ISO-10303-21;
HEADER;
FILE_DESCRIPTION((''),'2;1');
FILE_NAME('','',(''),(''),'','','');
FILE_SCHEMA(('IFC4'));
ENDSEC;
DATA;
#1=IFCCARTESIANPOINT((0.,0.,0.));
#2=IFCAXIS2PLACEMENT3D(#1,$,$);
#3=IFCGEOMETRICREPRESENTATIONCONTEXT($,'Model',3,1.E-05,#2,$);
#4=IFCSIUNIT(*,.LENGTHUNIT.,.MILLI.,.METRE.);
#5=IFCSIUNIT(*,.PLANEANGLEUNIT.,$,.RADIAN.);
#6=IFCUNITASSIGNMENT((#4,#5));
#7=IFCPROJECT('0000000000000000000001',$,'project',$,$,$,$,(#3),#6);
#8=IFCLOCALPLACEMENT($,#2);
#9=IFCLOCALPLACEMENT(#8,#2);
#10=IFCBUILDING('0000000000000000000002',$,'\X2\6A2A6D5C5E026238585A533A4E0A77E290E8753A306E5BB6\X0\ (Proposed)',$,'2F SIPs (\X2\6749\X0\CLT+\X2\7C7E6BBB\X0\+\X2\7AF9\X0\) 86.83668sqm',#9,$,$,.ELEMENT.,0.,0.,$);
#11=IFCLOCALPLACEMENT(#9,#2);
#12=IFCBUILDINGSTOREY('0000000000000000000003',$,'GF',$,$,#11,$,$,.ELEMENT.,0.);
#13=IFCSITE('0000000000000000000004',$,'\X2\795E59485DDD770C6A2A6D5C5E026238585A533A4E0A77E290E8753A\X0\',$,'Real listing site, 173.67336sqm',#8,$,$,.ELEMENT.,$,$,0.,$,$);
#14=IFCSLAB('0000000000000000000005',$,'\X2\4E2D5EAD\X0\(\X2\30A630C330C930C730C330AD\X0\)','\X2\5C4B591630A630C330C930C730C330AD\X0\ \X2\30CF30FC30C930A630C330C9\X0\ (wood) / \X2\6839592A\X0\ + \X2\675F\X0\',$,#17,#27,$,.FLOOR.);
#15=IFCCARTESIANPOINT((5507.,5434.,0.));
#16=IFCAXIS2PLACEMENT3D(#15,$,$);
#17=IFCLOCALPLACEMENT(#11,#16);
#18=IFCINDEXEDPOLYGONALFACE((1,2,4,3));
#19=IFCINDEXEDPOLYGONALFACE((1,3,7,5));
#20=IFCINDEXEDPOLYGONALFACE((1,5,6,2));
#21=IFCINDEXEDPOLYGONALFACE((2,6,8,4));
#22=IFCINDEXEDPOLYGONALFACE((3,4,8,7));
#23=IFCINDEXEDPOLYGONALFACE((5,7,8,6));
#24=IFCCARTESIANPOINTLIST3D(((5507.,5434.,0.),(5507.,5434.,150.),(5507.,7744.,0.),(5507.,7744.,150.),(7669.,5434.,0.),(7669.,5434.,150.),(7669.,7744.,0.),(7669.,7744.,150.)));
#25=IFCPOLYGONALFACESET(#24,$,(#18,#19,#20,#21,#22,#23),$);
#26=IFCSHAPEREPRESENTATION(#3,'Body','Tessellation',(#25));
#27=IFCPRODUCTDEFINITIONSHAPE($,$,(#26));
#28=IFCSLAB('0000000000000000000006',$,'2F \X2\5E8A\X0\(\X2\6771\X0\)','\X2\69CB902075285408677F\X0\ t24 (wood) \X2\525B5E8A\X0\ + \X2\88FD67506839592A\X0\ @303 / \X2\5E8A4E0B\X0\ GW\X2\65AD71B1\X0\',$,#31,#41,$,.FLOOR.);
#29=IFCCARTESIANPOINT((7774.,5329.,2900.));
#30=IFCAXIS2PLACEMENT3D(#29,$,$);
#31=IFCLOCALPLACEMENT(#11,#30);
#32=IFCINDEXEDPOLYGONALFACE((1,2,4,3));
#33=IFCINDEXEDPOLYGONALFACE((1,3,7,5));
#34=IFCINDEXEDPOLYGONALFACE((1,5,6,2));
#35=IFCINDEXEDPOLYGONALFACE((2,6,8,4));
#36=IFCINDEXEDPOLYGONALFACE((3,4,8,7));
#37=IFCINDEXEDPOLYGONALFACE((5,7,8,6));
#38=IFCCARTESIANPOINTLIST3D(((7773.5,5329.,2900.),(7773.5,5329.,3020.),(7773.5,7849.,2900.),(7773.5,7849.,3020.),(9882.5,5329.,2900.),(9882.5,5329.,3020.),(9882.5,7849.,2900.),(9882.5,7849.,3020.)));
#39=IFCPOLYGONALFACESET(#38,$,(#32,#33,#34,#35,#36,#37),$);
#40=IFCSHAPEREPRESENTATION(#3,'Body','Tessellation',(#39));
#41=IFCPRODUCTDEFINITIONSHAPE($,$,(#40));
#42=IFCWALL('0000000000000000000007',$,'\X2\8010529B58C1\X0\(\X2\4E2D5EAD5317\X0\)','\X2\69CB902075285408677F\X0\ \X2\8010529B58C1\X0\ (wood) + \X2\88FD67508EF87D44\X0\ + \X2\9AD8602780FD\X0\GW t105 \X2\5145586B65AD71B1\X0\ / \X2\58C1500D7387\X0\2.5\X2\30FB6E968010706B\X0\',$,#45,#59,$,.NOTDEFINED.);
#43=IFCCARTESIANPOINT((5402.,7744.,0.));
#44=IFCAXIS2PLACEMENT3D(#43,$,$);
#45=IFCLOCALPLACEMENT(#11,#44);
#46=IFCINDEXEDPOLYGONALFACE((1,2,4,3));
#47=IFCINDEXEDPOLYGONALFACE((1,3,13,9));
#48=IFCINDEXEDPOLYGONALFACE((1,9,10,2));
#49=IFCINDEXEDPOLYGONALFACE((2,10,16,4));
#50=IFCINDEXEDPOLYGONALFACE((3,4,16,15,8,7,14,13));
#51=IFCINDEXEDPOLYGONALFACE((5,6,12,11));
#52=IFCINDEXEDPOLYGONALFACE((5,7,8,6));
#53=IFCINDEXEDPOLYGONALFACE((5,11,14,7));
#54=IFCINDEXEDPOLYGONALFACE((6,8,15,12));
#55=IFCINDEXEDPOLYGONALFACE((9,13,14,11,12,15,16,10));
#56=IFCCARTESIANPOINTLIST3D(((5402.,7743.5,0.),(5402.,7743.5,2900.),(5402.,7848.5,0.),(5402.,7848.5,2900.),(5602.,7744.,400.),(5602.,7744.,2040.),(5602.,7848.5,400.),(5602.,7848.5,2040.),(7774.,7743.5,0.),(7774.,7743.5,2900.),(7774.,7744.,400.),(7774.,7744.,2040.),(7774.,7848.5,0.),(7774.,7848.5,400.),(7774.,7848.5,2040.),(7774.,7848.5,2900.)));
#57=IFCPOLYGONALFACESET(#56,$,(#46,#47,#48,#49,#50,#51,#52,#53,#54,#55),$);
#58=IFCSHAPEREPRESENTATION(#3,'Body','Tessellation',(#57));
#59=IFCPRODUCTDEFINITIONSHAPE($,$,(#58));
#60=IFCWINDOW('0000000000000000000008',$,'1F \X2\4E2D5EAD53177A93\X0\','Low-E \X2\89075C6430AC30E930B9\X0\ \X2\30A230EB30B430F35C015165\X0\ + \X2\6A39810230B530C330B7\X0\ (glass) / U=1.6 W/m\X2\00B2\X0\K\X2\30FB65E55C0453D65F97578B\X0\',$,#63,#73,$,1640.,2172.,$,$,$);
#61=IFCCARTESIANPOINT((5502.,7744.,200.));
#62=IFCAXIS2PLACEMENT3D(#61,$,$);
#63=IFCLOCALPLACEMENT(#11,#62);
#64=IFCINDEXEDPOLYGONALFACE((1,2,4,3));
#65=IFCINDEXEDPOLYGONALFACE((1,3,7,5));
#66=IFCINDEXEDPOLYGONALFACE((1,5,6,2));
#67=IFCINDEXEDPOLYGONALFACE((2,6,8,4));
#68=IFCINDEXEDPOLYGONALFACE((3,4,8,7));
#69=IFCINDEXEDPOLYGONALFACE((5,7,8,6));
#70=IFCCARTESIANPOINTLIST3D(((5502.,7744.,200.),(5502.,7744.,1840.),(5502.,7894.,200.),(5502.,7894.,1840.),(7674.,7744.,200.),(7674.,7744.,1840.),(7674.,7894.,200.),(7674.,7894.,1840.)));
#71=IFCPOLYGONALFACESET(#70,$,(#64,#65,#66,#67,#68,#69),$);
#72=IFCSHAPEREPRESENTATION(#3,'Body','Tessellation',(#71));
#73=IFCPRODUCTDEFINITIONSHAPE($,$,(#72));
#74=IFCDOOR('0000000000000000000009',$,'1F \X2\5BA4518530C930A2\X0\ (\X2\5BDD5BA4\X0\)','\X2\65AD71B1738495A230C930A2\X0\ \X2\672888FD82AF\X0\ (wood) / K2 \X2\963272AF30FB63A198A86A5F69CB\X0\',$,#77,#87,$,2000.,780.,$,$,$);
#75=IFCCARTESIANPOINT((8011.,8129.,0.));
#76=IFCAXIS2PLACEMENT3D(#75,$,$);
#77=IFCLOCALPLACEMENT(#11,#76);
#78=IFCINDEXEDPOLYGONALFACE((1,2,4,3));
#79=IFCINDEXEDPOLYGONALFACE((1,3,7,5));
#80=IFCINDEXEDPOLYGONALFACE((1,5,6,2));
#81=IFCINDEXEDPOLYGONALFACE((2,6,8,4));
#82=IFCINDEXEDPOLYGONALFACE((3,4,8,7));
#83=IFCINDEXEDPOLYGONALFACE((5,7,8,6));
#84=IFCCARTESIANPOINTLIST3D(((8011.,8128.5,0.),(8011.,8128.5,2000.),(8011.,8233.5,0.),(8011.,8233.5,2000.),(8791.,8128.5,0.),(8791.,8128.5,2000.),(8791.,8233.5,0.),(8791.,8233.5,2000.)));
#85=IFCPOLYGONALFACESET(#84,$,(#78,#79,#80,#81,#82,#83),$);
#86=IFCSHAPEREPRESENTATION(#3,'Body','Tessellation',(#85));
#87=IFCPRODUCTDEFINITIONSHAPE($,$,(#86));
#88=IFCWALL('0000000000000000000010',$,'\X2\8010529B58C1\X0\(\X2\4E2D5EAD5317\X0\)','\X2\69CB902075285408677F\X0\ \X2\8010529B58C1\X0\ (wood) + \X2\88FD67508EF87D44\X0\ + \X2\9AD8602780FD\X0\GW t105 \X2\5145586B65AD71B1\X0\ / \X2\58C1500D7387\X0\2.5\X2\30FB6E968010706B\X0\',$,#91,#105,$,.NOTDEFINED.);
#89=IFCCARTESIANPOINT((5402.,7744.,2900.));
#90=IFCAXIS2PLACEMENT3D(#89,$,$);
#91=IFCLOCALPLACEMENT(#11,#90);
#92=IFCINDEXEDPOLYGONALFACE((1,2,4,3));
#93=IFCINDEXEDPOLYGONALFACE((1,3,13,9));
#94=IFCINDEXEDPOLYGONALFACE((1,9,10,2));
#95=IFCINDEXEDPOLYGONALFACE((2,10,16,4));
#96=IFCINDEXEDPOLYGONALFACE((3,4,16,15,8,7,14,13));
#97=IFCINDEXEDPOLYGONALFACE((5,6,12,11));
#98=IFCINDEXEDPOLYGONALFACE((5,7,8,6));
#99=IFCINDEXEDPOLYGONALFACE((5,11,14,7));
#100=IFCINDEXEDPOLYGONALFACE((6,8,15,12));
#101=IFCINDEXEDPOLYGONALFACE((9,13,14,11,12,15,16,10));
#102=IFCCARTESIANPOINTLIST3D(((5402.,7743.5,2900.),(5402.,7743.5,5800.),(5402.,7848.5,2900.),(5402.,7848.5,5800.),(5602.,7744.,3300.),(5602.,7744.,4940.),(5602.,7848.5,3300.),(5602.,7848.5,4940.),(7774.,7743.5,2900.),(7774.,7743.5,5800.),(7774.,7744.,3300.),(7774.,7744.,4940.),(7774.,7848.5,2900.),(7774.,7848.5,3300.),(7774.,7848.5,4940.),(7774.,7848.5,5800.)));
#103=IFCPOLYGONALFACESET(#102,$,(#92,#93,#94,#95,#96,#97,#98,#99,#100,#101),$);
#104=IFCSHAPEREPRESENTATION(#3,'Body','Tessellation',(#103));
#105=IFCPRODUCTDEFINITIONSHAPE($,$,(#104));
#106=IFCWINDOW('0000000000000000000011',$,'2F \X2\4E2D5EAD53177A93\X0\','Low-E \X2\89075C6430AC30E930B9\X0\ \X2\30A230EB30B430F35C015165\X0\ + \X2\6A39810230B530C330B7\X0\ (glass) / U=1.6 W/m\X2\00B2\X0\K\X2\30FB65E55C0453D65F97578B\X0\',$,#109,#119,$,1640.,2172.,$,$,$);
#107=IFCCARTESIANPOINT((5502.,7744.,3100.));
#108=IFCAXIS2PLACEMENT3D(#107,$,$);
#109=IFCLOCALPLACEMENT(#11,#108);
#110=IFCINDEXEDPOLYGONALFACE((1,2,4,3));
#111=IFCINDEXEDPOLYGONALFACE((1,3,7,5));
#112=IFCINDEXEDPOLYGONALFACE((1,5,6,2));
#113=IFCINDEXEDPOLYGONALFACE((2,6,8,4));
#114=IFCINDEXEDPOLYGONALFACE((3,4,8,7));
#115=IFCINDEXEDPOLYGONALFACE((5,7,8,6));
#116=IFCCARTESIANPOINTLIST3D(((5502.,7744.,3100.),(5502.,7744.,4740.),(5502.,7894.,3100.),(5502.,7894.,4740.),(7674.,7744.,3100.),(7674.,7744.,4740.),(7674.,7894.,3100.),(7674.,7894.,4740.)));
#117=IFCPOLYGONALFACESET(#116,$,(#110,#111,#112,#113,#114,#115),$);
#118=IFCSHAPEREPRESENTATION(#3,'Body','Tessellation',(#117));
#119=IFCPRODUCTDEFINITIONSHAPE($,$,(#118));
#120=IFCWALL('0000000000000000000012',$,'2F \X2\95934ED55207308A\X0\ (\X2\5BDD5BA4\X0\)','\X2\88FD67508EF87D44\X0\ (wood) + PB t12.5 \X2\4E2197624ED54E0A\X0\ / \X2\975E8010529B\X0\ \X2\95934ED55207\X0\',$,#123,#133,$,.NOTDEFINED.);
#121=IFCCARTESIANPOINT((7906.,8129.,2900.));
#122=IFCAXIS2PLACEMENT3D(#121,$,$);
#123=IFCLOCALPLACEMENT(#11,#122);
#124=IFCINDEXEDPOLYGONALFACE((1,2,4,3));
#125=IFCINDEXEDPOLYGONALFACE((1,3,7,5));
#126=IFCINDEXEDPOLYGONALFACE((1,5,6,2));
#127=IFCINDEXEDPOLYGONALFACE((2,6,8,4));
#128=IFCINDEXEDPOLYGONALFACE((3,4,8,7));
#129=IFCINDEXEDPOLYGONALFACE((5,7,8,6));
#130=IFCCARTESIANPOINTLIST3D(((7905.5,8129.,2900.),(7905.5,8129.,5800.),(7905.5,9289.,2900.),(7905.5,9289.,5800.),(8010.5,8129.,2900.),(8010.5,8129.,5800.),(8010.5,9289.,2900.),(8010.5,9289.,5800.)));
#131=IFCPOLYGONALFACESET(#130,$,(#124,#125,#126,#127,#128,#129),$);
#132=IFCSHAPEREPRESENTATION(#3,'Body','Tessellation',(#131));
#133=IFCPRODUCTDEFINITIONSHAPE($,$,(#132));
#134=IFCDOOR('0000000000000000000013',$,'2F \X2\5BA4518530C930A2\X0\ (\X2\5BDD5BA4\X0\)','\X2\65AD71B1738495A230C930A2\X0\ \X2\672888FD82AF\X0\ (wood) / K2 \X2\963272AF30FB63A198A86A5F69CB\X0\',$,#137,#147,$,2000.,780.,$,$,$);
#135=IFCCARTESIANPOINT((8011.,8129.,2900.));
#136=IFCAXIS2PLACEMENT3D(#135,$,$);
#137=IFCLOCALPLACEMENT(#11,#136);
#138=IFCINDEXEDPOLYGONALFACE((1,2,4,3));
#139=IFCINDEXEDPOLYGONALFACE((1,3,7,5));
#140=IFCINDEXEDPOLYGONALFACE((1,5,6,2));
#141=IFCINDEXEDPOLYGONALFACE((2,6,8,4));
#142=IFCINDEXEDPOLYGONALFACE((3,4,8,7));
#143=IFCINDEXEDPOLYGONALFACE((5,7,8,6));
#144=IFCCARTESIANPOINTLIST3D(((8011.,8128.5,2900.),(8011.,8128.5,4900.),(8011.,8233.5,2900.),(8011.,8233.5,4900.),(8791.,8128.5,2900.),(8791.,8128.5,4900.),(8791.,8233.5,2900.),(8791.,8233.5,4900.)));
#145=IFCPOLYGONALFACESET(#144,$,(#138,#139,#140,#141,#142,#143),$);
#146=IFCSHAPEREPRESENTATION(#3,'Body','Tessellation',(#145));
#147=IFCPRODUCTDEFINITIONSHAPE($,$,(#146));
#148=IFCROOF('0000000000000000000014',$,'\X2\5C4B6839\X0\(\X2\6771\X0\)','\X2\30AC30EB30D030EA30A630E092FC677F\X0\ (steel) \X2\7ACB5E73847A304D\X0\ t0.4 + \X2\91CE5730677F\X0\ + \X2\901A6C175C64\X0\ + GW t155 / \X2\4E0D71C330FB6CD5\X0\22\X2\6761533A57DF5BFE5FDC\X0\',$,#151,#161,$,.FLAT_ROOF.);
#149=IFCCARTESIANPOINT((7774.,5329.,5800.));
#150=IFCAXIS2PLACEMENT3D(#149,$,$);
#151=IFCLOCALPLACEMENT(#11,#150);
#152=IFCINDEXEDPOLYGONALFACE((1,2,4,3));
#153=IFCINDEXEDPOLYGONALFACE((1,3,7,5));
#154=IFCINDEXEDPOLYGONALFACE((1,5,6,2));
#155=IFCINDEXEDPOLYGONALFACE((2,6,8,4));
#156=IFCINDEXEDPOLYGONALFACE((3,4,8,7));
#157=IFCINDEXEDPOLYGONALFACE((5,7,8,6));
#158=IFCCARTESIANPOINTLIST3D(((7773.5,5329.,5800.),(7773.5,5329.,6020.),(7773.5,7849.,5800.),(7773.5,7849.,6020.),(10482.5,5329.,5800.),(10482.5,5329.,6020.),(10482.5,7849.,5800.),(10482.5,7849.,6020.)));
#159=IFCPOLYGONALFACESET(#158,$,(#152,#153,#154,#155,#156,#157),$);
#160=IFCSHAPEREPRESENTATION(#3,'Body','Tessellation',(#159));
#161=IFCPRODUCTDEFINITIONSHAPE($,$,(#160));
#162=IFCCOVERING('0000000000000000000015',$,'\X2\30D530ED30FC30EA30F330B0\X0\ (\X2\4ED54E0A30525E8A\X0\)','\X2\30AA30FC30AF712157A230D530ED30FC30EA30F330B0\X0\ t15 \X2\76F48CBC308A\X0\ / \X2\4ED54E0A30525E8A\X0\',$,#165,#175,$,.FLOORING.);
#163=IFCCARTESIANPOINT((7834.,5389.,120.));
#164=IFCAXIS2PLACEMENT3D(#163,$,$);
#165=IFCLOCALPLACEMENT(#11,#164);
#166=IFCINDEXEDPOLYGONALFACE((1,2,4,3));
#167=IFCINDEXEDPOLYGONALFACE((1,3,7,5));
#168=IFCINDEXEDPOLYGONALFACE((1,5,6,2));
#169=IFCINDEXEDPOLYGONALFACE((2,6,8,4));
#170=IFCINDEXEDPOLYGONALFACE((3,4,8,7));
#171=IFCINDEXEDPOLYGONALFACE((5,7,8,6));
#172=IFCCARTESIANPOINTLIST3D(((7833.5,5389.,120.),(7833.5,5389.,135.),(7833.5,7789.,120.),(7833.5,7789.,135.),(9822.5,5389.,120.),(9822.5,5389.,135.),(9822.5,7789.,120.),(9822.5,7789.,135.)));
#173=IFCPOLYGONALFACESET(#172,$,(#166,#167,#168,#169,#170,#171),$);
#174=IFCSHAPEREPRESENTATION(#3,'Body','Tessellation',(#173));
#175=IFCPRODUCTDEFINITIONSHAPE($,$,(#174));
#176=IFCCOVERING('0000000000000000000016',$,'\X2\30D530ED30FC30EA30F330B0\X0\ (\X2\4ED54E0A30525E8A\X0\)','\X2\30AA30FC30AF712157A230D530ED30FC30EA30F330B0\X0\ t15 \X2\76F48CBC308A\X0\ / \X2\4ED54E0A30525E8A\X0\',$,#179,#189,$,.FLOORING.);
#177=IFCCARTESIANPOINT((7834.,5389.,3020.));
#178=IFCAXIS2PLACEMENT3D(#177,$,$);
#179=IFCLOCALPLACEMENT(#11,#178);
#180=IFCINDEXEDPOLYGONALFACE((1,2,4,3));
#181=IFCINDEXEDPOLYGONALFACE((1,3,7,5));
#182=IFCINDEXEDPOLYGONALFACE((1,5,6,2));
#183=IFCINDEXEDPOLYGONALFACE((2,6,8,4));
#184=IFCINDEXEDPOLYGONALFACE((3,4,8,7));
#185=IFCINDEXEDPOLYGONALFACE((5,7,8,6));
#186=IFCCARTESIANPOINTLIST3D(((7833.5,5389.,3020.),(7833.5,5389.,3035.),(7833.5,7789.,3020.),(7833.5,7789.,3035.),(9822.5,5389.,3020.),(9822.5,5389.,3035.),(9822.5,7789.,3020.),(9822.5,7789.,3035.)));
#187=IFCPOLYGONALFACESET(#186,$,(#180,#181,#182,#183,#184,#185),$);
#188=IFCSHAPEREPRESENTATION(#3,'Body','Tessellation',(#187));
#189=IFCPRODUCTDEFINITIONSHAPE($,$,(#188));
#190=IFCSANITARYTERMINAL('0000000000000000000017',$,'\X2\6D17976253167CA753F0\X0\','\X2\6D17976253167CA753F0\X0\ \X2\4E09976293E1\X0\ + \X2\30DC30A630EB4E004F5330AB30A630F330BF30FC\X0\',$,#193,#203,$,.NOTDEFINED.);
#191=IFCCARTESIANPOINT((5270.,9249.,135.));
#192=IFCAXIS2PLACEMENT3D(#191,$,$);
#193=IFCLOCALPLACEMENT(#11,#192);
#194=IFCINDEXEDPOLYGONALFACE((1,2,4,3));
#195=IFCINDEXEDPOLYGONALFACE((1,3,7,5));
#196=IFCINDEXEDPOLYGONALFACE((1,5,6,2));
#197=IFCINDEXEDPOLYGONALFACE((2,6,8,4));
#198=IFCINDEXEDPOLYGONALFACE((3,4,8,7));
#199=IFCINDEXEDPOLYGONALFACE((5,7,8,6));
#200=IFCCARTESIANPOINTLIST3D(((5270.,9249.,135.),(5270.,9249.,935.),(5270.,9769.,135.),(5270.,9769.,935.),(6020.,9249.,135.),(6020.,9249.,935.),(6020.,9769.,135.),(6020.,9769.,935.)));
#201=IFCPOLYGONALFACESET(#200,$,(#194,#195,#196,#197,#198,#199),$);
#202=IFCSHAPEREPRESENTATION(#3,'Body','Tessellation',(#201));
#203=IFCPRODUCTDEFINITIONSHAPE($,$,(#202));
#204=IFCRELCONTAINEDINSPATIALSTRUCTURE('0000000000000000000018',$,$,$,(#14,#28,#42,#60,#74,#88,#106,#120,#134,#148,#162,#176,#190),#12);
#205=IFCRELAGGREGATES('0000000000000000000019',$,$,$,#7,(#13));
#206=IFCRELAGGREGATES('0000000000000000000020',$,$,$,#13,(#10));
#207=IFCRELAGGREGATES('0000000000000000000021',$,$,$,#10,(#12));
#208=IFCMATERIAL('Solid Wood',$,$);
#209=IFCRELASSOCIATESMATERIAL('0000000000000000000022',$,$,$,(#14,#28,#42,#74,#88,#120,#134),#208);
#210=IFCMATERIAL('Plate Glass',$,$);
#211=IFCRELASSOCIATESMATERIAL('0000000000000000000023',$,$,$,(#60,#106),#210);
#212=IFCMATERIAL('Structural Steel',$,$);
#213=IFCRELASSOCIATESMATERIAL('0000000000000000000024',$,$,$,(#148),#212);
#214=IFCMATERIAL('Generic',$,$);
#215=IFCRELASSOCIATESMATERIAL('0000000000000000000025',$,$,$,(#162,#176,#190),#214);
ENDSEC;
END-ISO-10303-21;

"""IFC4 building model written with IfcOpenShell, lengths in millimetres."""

from ifc_helpers import new_model, si_unit, frame, frame_2d, origin, place, context, project, spatial, rectangle, extrude, material, element, fill, save


model = new_model("IFC4")

# Units and contexts
model_context = context("Model", 3, precision=1e-05, world=origin())
ifc_project = project(units=[si_unit("LENGTHUNIT", "METRE", prefix="MILLI"), si_unit("PLANEANGLEUNIT", "RADIAN")], contexts=[model_context])

# Site, building, storey
site_placement = place(None, origin())
site = spatial("IfcSite", under=ifc_project, at=site_placement, Name="神奈川県横浜市戸塚区上矢部町", ObjectType="Real listing site, 173.67336sqm", CompositionType="ELEMENT", RefElevation=0.0)
building_placement = place(site_placement, origin())
building = spatial("IfcBuilding", under=site, at=building_placement, Name="横浜市戸塚区上矢部町の家 (Proposed)", ObjectType="2F SIPs (杉CLT+籾殻+竹) 86.83668sqm", CompositionType="ELEMENT", ElevationOfRefHeight=0.0, ElevationOfTerrain=0.0)
storey_placement = place(building_placement, origin())
storey = spatial("IfcBuildingStorey", under=building, at=storey_placement, Name="GF", CompositionType="ELEMENT", Elevation=0.0)

# Slabs
ifc_material_1 = material(Name="Solid Wood")
slab_1_placement = place(storey_placement, frame((5507.0, 5434.0, 0.0)))
element("IfcSlab", 1, at=slab_1_placement, inside=storey, material=ifc_material_1, Name="中庭(ウッドデッキ)", Description="屋外ウッドデッキ ハードウッド (wood) / 根太 + 束", PredefinedType="FLOOR", context=model_context, shape_type="SweptSolid", body=[
    extrude(rectangle(XDim=2162.0, YDim=2310.0, at=frame_2d((1081.0, 1155.0))), frame((5507.0, 5434.0, 0.0)), (0.0, 0.0, 1.0), 150.0),
])
slab_2_placement = place(storey_placement, frame((7774.0, 5329.0, 2900.0)))
element("IfcSlab", 2, at=slab_2_placement, inside=storey, material=ifc_material_1, Name="2F 床(東)", Description="構造用合板 t24 (wood) 剛床 + 製材根太 @303 / 床下 GW断熱", PredefinedType="FLOOR", context=model_context, shape_type="SweptSolid", body=[
    extrude(rectangle(XDim=2109.0, YDim=2520.0, at=frame_2d((1054.0, 1260.0))), frame((7774.0, 5329.0, 2900.0)), (0.0, 0.0, 1.0), 120.0),
])

# Wall, opening, window
wall_1_placement = place(storey_placement, frame((5402.0, 7744.0, 0.0)))
wall_1 = element("IfcWall", 3, at=wall_1_placement, inside=storey, material=ifc_material_1, Name="耐力壁(中庭北)", Description="構造用合板 耐力壁 (wood) + 製材軸組 + 高性能GW t105 充填断熱 / 壁倍率2.5・準耐火", PredefinedType="NOTDEFINED", context=model_context, shape_type="SweptSolid", body=[
    extrude(rectangle(XDim=2372.0, YDim=105.0, at=frame_2d((1186.0, 52.0))), frame((5402.0, 7744.0, 0.0)), (0.0, 0.0, 1.0), 2900.0),
])
opening_1_placement = place(storey_placement, frame((5502.0, 7744.0, 200.0)))
opening_1 = element("IfcOpeningElement", 4, at=opening_1_placement, cuts=wall_1, PredefinedType="NOTDEFINED", context=model_context, shape_type="SweptSolid", body=[
    extrude(rectangle(XDim=2172.0, YDim=150.0, at=frame_2d((1086.0, 75.0))), frame((5502.0, 7744.0, 200.0)), (0.0, 0.0, 1.0), 1640.0),
])
ifc_material_2 = material(Name="Plate Glass")
window_1_placement = place(storey_placement, frame((5502.0, 7744.0, 200.0)))
window_1 = element("IfcWindow", 5, at=window_1_placement, inside=storey, material=ifc_material_2, Name="1F 中庭北窓", Description="Low-E 複層ガラス アルゴン封入 + 樹脂サッシ (glass) / U=1.6 W/m²K・日射取得型", OverallHeight=1640.0, OverallWidth=2172.0, context=model_context, shape_type="SweptSolid", body=[
    extrude(rectangle(XDim=2172.0, YDim=150.0, at=frame_2d((1086.0, 75.0))), frame((5502.0, 7744.0, 200.0)), (0.0, 0.0, 1.0), 1640.0),
])
fill(opening_1, window_1)

# Door
door_1_placement = place(storey_placement, frame((8011.0, 8129.0, 0.0)))
element("IfcDoor", 6, at=door_1_placement, inside=storey, material=ifc_material_1, Name="1F 室内ドア (寝室)", Description="断熱玄関ドア 木製芯 (wood) / K2 防犯・採風機構", OverallHeight=2000.0, OverallWidth=780.0, context=model_context, shape_type="SweptSolid", body=[
    extrude(rectangle(XDim=780.0, YDim=105.0, at=frame_2d((390.0, 52.0))), frame((8011.0, 8129.0, 0.0)), (0.0, 0.0, 1.0), 2000.0),
])

# Wall, opening, window
wall_2_placement = place(storey_placement, frame((5402.0, 7744.0, 2900.0)))
wall_2 = element("IfcWall", 7, at=wall_2_placement, inside=storey, material=ifc_material_1, Name="耐力壁(中庭北)", Description="構造用合板 耐力壁 (wood) + 製材軸組 + 高性能GW t105 充填断熱 / 壁倍率2.5・準耐火", PredefinedType="NOTDEFINED", context=model_context, shape_type="SweptSolid", body=[
    extrude(rectangle(XDim=2372.0, YDim=105.0, at=frame_2d((1186.0, 52.0))), frame((5402.0, 7744.0, 2900.0)), (0.0, 0.0, 1.0), 2900.0),
])
opening_2_placement = place(storey_placement, frame((5502.0, 7744.0, 3100.0)))
opening_2 = element("IfcOpeningElement", 8, at=opening_2_placement, cuts=wall_2, PredefinedType="NOTDEFINED", context=model_context, shape_type="SweptSolid", body=[
    extrude(rectangle(XDim=2172.0, YDim=150.0, at=frame_2d((1086.0, 75.0))), frame((5502.0, 7744.0, 3100.0)), (0.0, 0.0, 1.0), 1640.0),
])
window_2_placement = place(storey_placement, frame((5502.0, 7744.0, 3100.0)))
window_2 = element("IfcWindow", 9, at=window_2_placement, inside=storey, material=ifc_material_2, Name="2F 中庭北窓", Description="Low-E 複層ガラス アルゴン封入 + 樹脂サッシ (glass) / U=1.6 W/m²K・日射取得型", OverallHeight=1640.0, OverallWidth=2172.0, context=model_context, shape_type="SweptSolid", body=[
    extrude(rectangle(XDim=2172.0, YDim=150.0, at=frame_2d((1086.0, 75.0))), frame((5502.0, 7744.0, 3100.0)), (0.0, 0.0, 1.0), 1640.0),
])
fill(opening_2, window_2)

# Wall
wall_3_placement = place(storey_placement, frame((7906.0, 8129.0, 2900.0)))
element("IfcWall", 10, at=wall_3_placement, inside=storey, material=ifc_material_1, Name="2F 間仕切り (寝室)", Description="製材軸組 (wood) + PB t12.5 両面仕上 / 非耐力 間仕切", PredefinedType="NOTDEFINED", context=model_context, shape_type="SweptSolid", body=[
    extrude(rectangle(XDim=105.0, YDim=1160.0, at=frame_2d((52.0, 580.0))), frame((7906.0, 8129.0, 2900.0)), (0.0, 0.0, 1.0), 2900.0),
])

# Door
door_2_placement = place(storey_placement, frame((8011.0, 8129.0, 2900.0)))
element("IfcDoor", 11, at=door_2_placement, inside=storey, material=ifc_material_1, Name="2F 室内ドア (寝室)", Description="断熱玄関ドア 木製芯 (wood) / K2 防犯・採風機構", OverallHeight=2000.0, OverallWidth=780.0, context=model_context, shape_type="SweptSolid", body=[
    extrude(rectangle(XDim=780.0, YDim=105.0, at=frame_2d((390.0, 52.0))), frame((8011.0, 8129.0, 2900.0)), (0.0, 0.0, 1.0), 2000.0),
])

# Roof
ifc_material_3 = material(Name="Structural Steel")
for number, where, name in (
    (12, (7774.0, 5329.0, 5800.0), "屋根(東)"),
):
    element("IfcRoof", number, at=place(storey_placement, frame(where)), inside=storey, material=ifc_material_3, Name=name, Description="ガルバリウム鋼板 (steel) 立平葺き t0.4 + 野地板 + 通気層 + GW t155 / 不燃・法22条区域対応", PredefinedType="FLAT_ROOF", context=model_context, shape_type="SweptSolid", body=[
        extrude(rectangle(XDim=2709.0, YDim=2520.0, at=frame_2d((1354.0, 1260.0))), frame((7774.0, 5329.0, 5800.0)), (0.0, 0.0, 1.0), 220.0),
    ])

# Coverings
ifc_material_4 = material(Name="Generic")
covering_1_placement = place(storey_placement, frame((7834.0, 5389.0, 120.0)))
element("IfcCovering", 13, at=covering_1_placement, inside=storey, material=ifc_material_4, Name="フローリング (仕上げ床)", Description="オーク無垢フローリング t15 直貼り / 仕上げ床", PredefinedType="FLOORING", context=model_context, shape_type="SweptSolid", body=[
    extrude(rectangle(XDim=1989.0, YDim=2400.0, at=frame_2d((994.0, 1200.0))), frame((7834.0, 5389.0, 120.0)), (0.0, 0.0, 1.0), 15.0),
])
covering_2_placement = place(storey_placement, frame((7834.0, 5389.0, 3020.0)))
element("IfcCovering", 14, at=covering_2_placement, inside=storey, material=ifc_material_4, Name="フローリング (仕上げ床)", Description="オーク無垢フローリング t15 直貼り / 仕上げ床", PredefinedType="FLOORING", context=model_context, shape_type="SweptSolid", body=[
    extrude(rectangle(XDim=1989.0, YDim=2400.0, at=frame_2d((994.0, 1200.0))), frame((7834.0, 5389.0, 3020.0)), (0.0, 0.0, 1.0), 15.0),
])

# Sanitary terminal
sanitary_terminal_1_placement = place(storey_placement, frame((5270.0, 9249.0, 135.0)))
element("IfcSanitaryTerminal", 15, at=sanitary_terminal_1_placement, inside=storey, material=ifc_material_4, Name="洗面化粧台", Description="洗面化粧台 三面鏡 + ボウル一体カウンター", PredefinedType="NOTDEFINED", context=model_context, shape_type="SweptSolid", body=[
    extrude(rectangle(XDim=750.0, YDim=520.0, at=frame_2d((375.0, 260.0))), frame((5270.0, 9249.0, 135.0)), (0.0, 0.0, 1.0), 800.0),
])

save(model, "model.ifc")
